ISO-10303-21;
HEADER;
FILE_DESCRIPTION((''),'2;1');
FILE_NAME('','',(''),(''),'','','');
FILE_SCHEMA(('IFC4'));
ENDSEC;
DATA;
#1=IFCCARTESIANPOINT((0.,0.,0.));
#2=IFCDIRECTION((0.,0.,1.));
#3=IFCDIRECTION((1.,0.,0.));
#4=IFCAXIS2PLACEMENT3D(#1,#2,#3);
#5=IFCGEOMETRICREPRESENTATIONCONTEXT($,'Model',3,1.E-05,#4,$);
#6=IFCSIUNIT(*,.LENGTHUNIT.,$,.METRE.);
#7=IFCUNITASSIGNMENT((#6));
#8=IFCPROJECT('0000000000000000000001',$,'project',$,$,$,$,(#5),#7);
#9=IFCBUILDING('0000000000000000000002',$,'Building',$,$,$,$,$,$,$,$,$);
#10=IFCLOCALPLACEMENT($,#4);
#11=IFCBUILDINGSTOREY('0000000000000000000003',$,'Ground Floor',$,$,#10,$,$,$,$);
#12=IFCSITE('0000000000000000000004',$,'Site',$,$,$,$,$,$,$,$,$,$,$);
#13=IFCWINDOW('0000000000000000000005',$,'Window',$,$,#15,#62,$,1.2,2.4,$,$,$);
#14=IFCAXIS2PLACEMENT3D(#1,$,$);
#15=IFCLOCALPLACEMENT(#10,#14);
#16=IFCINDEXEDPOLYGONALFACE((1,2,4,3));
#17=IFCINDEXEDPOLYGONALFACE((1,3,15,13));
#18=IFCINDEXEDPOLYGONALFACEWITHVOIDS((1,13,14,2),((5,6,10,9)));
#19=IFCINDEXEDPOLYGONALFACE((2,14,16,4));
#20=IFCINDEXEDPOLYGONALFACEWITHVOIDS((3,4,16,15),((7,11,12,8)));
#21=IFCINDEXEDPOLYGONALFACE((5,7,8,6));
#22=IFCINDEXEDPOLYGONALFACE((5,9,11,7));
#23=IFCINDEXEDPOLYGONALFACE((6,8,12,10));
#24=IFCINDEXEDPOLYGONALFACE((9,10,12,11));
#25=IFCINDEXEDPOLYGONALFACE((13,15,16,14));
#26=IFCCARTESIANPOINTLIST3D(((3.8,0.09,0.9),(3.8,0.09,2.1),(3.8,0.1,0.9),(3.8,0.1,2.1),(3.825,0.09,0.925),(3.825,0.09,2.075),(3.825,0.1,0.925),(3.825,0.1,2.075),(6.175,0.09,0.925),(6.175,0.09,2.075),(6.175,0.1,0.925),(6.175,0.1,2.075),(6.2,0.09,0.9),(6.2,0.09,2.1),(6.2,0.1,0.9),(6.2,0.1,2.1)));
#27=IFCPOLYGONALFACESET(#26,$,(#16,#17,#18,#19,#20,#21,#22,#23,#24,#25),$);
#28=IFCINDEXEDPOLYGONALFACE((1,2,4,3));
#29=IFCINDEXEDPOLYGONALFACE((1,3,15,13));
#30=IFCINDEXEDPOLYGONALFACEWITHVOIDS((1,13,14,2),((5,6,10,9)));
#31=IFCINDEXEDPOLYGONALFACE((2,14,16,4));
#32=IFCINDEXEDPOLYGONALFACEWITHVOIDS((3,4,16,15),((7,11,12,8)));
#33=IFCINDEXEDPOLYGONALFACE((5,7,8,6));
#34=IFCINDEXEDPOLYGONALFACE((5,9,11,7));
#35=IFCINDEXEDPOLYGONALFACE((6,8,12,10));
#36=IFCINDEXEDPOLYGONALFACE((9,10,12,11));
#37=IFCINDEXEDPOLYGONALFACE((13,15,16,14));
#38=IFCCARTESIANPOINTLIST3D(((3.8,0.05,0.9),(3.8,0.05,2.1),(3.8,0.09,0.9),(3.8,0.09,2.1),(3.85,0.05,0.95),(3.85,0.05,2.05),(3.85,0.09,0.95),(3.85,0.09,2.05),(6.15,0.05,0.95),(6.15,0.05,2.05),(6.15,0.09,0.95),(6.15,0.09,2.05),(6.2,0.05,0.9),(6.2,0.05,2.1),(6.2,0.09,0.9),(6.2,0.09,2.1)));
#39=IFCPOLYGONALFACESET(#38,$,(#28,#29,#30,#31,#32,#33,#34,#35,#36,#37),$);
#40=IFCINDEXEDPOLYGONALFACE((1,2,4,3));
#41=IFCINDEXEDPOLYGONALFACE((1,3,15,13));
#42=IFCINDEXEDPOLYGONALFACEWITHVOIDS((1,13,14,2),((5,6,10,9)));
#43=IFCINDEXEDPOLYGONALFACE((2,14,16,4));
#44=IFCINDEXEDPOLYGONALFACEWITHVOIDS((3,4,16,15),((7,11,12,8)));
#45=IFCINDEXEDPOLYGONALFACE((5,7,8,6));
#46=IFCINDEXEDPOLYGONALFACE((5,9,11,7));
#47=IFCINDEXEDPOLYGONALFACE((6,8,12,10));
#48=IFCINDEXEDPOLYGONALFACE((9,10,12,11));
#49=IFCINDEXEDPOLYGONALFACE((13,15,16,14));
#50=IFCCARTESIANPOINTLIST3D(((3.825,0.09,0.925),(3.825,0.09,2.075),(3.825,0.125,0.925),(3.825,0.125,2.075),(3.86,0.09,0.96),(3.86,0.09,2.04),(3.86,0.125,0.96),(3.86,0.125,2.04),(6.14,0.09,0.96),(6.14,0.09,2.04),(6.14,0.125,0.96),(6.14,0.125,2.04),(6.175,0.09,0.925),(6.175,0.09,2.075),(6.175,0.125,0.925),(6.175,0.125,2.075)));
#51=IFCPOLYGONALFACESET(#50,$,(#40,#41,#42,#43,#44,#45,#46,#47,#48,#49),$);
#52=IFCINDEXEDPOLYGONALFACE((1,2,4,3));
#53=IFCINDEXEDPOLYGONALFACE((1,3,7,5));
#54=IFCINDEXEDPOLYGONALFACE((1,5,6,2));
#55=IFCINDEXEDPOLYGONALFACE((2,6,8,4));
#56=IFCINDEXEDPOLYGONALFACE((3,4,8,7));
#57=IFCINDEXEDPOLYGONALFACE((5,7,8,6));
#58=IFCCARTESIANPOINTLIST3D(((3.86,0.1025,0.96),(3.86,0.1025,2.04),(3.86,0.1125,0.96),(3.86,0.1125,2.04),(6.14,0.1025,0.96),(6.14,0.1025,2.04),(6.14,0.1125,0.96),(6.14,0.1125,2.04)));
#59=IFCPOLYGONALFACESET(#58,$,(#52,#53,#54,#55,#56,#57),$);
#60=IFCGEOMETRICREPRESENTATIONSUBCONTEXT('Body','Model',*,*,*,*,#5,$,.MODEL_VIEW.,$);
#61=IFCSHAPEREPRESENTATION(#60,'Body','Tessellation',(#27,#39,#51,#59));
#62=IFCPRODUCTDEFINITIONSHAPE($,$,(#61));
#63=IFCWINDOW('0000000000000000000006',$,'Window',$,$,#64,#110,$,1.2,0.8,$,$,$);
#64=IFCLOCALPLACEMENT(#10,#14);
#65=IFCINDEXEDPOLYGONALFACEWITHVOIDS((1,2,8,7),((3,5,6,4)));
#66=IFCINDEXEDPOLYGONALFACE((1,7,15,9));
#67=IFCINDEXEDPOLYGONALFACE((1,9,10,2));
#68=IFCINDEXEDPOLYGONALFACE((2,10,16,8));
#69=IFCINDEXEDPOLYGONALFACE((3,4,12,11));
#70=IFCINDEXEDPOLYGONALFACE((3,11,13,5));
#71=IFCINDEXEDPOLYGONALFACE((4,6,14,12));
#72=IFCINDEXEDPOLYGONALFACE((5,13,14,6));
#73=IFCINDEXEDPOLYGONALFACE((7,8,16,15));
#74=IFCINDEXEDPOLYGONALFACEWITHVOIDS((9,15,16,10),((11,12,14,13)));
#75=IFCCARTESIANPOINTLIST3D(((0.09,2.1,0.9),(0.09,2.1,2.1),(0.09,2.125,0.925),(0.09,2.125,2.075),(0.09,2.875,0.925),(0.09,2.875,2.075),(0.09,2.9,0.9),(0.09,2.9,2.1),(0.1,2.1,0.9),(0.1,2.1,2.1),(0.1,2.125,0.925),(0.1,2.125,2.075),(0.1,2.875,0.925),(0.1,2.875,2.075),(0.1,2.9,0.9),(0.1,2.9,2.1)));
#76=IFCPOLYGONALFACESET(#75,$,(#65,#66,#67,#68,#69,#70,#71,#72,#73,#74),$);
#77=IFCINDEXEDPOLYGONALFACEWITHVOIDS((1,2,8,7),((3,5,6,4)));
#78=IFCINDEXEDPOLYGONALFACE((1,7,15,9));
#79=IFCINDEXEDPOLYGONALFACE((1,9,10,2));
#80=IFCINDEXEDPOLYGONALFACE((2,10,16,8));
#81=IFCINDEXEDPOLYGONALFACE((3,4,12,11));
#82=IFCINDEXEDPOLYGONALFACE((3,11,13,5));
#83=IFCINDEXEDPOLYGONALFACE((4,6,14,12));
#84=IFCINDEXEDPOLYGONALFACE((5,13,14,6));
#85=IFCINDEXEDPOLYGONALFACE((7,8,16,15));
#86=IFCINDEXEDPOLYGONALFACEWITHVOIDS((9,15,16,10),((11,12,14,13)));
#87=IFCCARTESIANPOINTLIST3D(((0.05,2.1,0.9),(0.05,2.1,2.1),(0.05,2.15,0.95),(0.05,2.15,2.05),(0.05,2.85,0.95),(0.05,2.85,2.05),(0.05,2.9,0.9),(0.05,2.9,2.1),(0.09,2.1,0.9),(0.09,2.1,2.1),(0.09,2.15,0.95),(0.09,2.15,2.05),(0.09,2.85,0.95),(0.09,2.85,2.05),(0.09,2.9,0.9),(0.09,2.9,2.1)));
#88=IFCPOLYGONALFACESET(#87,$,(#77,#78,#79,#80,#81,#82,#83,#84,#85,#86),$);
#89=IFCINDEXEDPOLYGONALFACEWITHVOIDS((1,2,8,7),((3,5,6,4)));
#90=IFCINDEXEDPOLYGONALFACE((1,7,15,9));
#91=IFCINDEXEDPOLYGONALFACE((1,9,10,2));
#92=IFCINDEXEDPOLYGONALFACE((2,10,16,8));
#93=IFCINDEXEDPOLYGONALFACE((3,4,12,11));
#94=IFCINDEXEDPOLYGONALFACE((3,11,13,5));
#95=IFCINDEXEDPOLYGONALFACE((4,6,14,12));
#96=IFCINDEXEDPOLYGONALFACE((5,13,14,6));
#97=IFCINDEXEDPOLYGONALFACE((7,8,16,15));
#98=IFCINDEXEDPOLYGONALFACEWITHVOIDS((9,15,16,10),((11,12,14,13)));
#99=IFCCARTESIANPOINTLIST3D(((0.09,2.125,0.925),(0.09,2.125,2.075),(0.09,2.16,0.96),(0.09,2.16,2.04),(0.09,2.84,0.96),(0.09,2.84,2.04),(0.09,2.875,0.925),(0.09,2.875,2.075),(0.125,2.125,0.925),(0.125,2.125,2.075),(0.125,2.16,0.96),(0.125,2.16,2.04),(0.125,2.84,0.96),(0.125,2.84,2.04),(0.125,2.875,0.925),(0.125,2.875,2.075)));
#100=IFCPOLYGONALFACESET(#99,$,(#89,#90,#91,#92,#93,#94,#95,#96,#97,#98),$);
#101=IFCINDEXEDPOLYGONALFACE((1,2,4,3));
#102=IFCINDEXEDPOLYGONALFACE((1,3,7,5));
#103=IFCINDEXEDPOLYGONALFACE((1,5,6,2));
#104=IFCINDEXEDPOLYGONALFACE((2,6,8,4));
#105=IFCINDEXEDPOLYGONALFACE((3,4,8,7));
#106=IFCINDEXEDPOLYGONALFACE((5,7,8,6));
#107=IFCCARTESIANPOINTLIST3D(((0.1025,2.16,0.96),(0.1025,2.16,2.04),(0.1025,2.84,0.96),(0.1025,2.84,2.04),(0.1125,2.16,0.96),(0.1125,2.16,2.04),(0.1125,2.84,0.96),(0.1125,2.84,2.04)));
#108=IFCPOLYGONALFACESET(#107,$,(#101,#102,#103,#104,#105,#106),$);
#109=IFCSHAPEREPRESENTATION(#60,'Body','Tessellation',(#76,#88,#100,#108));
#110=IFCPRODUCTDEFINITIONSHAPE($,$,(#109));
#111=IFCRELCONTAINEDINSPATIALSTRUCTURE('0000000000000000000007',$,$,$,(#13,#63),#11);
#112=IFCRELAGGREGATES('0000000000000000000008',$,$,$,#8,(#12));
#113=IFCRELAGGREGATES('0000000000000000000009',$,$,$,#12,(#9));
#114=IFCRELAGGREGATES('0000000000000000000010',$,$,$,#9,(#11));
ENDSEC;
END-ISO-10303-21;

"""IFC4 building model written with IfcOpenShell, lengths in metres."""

from ifc_helpers import new_model, si_unit, frame, origin_with_axes, place, context, subcontext, project, spatial, line, indexed_curve, outline, extrude, element, save


model = new_model("IFC4")

# Units and contexts
model_context = context("Model", 3, precision=1e-05, world=origin_with_axes())
body_context = subcontext(model_context, "Body", "Model", "MODEL_VIEW")
ifc_project = project(units=[si_unit("LENGTHUNIT", "METRE")], contexts=[model_context])

# Site, building, storey
site = spatial("IfcSite", under=ifc_project, Name="Site")
building = spatial("IfcBuilding", under=site, Name="Building")
storey_placement = place(None, origin_with_axes())
storey = spatial("IfcBuildingStorey", under=building, at=storey_placement, Name="Ground Floor")

# Windows
window_1_placement = place(storey_placement, frame((3.8, 0.0, 0.9), z_axis=(0.0, 0.0, 1.0), x_axis=(1.0, 0.0, 0.0)))
element("IfcWindow", 1, at=window_1_placement, inside=storey, Name="Window", OverallHeight=1.2, OverallWidth=2.4, context=body_context, shape_type="SweptSolid", body=[
    extrude(outline(indexed_curve([(0.0, 0.0), (2.4, 0.0), (2.4, 1.2), (0.0, 1.2)], segments=[line(1, 2, 3, 4, 1)]), holes=[indexed_curve([(0.025, 0.025), (2.375, 0.025), (2.375, 1.175), (0.025, 1.175)], segments=[line(1, 2, 3, 4, 1)])]), frame((0.0, 0.09, 0.0), z_axis=(0.0, -1.0, 0.0), x_axis=(1.0, 0.0, 0.0)), (0.0, 0.0, -1.0), 0.01),
    extrude(outline(indexed_curve([(0.0, 0.0), (2.4, 0.0), (2.4, 1.2), (0.0, 1.2)], segments=[line(1, 2, 3, 4, 1)]), holes=[indexed_curve([(0.05, 0.05), (2.35, 0.05), (2.35, 1.15), (0.05, 1.15)], segments=[line(1, 2, 3, 4, 1)])]), frame((0.0, 0.05, 0.0), z_axis=(0.0, -1.0, 0.0), x_axis=(1.0, 0.0, 0.0)), (0.0, 0.0, -1.0), 0.04),
    extrude(outline(indexed_curve([(0.0, 0.0), (2.35, 0.0), (2.35, 1.15), (0.0, 1.15)], segments=[line(1, 2, 3, 4, 1)]), holes=[indexed_curve([(0.035, 0.035), (2.315, 0.035), (2.315, 1.115), (0.035, 1.115)], segments=[line(1, 2, 3, 4, 1)])]), frame((0.025, 0.09, 0.025), z_axis=(0.0, -1.0, 0.0), x_axis=(1.0, 0.0, 0.0)), (0.0, 0.0, -1.0), 0.035),
    extrude(outline(indexed_curve([(0.035, 0.035), (2.315, 0.035), (2.315, 1.115), (0.035, 1.115)], segments=[line(1, 2, 3, 4, 1)])), frame((0.025, 0.1025, 0.025), z_axis=(0.0, -1.0, 0.0), x_axis=(1.0, 0.0, 0.0)), (0.0, 0.0, -1.0), 0.01),
])
window_2_placement = place(storey_placement, frame((0.0, 2.9, 0.9), z_axis=(0.0, 0.0, 1.0), x_axis=(0.0, -1.0, 0.0)))
element("IfcWindow", 2, at=window_2_placement, inside=storey, Name="Window", OverallHeight=1.2, OverallWidth=0.8, context=body_context, shape_type="SweptSolid", body=[
    extrude(outline(indexed_curve([(0.0, 0.0), (0.8, 0.0), (0.8, 1.2), (0.0, 1.2)], segments=[line(1, 2, 3, 4, 1)]), holes=[indexed_curve([(0.025, 0.025), (0.775, 0.025), (0.775, 1.175), (0.025, 1.175)], segments=[line(1, 2, 3, 4, 1)])]), frame((0.0, 0.09, 0.0), z_axis=(0.0, -1.0, 0.0), x_axis=(1.0, 0.0, 0.0)), (0.0, 0.0, -1.0), 0.01),
    extrude(outline(indexed_curve([(0.0, 0.0), (0.8, 0.0), (0.8, 1.2), (0.0, 1.2)], segments=[line(1, 2, 3, 4, 1)]), holes=[indexed_curve([(0.05, 0.05), (0.75, 0.05), (0.75, 1.15), (0.05, 1.15)], segments=[line(1, 2, 3, 4, 1)])]), frame((0.0, 0.05, 0.0), z_axis=(0.0, -1.0, 0.0), x_axis=(1.0, 0.0, 0.0)), (0.0, 0.0, -1.0), 0.04),
    extrude(outline(indexed_curve([(0.0, 0.0), (0.75, 0.0), (0.75, 1.15), (0.0, 1.15)], segments=[line(1, 2, 3, 4, 1)]), holes=[indexed_curve([(0.035, 0.035), (0.715, 0.035), (0.715, 1.115), (0.035, 1.115)], segments=[line(1, 2, 3, 4, 1)])]), frame((0.025, 0.09, 0.025), z_axis=(0.0, -1.0, 0.0), x_axis=(1.0, 0.0, 0.0)), (0.0, 0.0, -1.0), 0.035),
    extrude(outline(indexed_curve([(0.035, 0.035), (0.715, 0.035), (0.715, 1.115), (0.035, 1.115)], segments=[line(1, 2, 3, 4, 1)])), frame((0.025, 0.1025, 0.025), z_axis=(0.0, -1.0, 0.0), x_axis=(1.0, 0.0, 0.0)), (0.0, 0.0, -1.0), 0.01),
])

save(model, "model.ifc")
